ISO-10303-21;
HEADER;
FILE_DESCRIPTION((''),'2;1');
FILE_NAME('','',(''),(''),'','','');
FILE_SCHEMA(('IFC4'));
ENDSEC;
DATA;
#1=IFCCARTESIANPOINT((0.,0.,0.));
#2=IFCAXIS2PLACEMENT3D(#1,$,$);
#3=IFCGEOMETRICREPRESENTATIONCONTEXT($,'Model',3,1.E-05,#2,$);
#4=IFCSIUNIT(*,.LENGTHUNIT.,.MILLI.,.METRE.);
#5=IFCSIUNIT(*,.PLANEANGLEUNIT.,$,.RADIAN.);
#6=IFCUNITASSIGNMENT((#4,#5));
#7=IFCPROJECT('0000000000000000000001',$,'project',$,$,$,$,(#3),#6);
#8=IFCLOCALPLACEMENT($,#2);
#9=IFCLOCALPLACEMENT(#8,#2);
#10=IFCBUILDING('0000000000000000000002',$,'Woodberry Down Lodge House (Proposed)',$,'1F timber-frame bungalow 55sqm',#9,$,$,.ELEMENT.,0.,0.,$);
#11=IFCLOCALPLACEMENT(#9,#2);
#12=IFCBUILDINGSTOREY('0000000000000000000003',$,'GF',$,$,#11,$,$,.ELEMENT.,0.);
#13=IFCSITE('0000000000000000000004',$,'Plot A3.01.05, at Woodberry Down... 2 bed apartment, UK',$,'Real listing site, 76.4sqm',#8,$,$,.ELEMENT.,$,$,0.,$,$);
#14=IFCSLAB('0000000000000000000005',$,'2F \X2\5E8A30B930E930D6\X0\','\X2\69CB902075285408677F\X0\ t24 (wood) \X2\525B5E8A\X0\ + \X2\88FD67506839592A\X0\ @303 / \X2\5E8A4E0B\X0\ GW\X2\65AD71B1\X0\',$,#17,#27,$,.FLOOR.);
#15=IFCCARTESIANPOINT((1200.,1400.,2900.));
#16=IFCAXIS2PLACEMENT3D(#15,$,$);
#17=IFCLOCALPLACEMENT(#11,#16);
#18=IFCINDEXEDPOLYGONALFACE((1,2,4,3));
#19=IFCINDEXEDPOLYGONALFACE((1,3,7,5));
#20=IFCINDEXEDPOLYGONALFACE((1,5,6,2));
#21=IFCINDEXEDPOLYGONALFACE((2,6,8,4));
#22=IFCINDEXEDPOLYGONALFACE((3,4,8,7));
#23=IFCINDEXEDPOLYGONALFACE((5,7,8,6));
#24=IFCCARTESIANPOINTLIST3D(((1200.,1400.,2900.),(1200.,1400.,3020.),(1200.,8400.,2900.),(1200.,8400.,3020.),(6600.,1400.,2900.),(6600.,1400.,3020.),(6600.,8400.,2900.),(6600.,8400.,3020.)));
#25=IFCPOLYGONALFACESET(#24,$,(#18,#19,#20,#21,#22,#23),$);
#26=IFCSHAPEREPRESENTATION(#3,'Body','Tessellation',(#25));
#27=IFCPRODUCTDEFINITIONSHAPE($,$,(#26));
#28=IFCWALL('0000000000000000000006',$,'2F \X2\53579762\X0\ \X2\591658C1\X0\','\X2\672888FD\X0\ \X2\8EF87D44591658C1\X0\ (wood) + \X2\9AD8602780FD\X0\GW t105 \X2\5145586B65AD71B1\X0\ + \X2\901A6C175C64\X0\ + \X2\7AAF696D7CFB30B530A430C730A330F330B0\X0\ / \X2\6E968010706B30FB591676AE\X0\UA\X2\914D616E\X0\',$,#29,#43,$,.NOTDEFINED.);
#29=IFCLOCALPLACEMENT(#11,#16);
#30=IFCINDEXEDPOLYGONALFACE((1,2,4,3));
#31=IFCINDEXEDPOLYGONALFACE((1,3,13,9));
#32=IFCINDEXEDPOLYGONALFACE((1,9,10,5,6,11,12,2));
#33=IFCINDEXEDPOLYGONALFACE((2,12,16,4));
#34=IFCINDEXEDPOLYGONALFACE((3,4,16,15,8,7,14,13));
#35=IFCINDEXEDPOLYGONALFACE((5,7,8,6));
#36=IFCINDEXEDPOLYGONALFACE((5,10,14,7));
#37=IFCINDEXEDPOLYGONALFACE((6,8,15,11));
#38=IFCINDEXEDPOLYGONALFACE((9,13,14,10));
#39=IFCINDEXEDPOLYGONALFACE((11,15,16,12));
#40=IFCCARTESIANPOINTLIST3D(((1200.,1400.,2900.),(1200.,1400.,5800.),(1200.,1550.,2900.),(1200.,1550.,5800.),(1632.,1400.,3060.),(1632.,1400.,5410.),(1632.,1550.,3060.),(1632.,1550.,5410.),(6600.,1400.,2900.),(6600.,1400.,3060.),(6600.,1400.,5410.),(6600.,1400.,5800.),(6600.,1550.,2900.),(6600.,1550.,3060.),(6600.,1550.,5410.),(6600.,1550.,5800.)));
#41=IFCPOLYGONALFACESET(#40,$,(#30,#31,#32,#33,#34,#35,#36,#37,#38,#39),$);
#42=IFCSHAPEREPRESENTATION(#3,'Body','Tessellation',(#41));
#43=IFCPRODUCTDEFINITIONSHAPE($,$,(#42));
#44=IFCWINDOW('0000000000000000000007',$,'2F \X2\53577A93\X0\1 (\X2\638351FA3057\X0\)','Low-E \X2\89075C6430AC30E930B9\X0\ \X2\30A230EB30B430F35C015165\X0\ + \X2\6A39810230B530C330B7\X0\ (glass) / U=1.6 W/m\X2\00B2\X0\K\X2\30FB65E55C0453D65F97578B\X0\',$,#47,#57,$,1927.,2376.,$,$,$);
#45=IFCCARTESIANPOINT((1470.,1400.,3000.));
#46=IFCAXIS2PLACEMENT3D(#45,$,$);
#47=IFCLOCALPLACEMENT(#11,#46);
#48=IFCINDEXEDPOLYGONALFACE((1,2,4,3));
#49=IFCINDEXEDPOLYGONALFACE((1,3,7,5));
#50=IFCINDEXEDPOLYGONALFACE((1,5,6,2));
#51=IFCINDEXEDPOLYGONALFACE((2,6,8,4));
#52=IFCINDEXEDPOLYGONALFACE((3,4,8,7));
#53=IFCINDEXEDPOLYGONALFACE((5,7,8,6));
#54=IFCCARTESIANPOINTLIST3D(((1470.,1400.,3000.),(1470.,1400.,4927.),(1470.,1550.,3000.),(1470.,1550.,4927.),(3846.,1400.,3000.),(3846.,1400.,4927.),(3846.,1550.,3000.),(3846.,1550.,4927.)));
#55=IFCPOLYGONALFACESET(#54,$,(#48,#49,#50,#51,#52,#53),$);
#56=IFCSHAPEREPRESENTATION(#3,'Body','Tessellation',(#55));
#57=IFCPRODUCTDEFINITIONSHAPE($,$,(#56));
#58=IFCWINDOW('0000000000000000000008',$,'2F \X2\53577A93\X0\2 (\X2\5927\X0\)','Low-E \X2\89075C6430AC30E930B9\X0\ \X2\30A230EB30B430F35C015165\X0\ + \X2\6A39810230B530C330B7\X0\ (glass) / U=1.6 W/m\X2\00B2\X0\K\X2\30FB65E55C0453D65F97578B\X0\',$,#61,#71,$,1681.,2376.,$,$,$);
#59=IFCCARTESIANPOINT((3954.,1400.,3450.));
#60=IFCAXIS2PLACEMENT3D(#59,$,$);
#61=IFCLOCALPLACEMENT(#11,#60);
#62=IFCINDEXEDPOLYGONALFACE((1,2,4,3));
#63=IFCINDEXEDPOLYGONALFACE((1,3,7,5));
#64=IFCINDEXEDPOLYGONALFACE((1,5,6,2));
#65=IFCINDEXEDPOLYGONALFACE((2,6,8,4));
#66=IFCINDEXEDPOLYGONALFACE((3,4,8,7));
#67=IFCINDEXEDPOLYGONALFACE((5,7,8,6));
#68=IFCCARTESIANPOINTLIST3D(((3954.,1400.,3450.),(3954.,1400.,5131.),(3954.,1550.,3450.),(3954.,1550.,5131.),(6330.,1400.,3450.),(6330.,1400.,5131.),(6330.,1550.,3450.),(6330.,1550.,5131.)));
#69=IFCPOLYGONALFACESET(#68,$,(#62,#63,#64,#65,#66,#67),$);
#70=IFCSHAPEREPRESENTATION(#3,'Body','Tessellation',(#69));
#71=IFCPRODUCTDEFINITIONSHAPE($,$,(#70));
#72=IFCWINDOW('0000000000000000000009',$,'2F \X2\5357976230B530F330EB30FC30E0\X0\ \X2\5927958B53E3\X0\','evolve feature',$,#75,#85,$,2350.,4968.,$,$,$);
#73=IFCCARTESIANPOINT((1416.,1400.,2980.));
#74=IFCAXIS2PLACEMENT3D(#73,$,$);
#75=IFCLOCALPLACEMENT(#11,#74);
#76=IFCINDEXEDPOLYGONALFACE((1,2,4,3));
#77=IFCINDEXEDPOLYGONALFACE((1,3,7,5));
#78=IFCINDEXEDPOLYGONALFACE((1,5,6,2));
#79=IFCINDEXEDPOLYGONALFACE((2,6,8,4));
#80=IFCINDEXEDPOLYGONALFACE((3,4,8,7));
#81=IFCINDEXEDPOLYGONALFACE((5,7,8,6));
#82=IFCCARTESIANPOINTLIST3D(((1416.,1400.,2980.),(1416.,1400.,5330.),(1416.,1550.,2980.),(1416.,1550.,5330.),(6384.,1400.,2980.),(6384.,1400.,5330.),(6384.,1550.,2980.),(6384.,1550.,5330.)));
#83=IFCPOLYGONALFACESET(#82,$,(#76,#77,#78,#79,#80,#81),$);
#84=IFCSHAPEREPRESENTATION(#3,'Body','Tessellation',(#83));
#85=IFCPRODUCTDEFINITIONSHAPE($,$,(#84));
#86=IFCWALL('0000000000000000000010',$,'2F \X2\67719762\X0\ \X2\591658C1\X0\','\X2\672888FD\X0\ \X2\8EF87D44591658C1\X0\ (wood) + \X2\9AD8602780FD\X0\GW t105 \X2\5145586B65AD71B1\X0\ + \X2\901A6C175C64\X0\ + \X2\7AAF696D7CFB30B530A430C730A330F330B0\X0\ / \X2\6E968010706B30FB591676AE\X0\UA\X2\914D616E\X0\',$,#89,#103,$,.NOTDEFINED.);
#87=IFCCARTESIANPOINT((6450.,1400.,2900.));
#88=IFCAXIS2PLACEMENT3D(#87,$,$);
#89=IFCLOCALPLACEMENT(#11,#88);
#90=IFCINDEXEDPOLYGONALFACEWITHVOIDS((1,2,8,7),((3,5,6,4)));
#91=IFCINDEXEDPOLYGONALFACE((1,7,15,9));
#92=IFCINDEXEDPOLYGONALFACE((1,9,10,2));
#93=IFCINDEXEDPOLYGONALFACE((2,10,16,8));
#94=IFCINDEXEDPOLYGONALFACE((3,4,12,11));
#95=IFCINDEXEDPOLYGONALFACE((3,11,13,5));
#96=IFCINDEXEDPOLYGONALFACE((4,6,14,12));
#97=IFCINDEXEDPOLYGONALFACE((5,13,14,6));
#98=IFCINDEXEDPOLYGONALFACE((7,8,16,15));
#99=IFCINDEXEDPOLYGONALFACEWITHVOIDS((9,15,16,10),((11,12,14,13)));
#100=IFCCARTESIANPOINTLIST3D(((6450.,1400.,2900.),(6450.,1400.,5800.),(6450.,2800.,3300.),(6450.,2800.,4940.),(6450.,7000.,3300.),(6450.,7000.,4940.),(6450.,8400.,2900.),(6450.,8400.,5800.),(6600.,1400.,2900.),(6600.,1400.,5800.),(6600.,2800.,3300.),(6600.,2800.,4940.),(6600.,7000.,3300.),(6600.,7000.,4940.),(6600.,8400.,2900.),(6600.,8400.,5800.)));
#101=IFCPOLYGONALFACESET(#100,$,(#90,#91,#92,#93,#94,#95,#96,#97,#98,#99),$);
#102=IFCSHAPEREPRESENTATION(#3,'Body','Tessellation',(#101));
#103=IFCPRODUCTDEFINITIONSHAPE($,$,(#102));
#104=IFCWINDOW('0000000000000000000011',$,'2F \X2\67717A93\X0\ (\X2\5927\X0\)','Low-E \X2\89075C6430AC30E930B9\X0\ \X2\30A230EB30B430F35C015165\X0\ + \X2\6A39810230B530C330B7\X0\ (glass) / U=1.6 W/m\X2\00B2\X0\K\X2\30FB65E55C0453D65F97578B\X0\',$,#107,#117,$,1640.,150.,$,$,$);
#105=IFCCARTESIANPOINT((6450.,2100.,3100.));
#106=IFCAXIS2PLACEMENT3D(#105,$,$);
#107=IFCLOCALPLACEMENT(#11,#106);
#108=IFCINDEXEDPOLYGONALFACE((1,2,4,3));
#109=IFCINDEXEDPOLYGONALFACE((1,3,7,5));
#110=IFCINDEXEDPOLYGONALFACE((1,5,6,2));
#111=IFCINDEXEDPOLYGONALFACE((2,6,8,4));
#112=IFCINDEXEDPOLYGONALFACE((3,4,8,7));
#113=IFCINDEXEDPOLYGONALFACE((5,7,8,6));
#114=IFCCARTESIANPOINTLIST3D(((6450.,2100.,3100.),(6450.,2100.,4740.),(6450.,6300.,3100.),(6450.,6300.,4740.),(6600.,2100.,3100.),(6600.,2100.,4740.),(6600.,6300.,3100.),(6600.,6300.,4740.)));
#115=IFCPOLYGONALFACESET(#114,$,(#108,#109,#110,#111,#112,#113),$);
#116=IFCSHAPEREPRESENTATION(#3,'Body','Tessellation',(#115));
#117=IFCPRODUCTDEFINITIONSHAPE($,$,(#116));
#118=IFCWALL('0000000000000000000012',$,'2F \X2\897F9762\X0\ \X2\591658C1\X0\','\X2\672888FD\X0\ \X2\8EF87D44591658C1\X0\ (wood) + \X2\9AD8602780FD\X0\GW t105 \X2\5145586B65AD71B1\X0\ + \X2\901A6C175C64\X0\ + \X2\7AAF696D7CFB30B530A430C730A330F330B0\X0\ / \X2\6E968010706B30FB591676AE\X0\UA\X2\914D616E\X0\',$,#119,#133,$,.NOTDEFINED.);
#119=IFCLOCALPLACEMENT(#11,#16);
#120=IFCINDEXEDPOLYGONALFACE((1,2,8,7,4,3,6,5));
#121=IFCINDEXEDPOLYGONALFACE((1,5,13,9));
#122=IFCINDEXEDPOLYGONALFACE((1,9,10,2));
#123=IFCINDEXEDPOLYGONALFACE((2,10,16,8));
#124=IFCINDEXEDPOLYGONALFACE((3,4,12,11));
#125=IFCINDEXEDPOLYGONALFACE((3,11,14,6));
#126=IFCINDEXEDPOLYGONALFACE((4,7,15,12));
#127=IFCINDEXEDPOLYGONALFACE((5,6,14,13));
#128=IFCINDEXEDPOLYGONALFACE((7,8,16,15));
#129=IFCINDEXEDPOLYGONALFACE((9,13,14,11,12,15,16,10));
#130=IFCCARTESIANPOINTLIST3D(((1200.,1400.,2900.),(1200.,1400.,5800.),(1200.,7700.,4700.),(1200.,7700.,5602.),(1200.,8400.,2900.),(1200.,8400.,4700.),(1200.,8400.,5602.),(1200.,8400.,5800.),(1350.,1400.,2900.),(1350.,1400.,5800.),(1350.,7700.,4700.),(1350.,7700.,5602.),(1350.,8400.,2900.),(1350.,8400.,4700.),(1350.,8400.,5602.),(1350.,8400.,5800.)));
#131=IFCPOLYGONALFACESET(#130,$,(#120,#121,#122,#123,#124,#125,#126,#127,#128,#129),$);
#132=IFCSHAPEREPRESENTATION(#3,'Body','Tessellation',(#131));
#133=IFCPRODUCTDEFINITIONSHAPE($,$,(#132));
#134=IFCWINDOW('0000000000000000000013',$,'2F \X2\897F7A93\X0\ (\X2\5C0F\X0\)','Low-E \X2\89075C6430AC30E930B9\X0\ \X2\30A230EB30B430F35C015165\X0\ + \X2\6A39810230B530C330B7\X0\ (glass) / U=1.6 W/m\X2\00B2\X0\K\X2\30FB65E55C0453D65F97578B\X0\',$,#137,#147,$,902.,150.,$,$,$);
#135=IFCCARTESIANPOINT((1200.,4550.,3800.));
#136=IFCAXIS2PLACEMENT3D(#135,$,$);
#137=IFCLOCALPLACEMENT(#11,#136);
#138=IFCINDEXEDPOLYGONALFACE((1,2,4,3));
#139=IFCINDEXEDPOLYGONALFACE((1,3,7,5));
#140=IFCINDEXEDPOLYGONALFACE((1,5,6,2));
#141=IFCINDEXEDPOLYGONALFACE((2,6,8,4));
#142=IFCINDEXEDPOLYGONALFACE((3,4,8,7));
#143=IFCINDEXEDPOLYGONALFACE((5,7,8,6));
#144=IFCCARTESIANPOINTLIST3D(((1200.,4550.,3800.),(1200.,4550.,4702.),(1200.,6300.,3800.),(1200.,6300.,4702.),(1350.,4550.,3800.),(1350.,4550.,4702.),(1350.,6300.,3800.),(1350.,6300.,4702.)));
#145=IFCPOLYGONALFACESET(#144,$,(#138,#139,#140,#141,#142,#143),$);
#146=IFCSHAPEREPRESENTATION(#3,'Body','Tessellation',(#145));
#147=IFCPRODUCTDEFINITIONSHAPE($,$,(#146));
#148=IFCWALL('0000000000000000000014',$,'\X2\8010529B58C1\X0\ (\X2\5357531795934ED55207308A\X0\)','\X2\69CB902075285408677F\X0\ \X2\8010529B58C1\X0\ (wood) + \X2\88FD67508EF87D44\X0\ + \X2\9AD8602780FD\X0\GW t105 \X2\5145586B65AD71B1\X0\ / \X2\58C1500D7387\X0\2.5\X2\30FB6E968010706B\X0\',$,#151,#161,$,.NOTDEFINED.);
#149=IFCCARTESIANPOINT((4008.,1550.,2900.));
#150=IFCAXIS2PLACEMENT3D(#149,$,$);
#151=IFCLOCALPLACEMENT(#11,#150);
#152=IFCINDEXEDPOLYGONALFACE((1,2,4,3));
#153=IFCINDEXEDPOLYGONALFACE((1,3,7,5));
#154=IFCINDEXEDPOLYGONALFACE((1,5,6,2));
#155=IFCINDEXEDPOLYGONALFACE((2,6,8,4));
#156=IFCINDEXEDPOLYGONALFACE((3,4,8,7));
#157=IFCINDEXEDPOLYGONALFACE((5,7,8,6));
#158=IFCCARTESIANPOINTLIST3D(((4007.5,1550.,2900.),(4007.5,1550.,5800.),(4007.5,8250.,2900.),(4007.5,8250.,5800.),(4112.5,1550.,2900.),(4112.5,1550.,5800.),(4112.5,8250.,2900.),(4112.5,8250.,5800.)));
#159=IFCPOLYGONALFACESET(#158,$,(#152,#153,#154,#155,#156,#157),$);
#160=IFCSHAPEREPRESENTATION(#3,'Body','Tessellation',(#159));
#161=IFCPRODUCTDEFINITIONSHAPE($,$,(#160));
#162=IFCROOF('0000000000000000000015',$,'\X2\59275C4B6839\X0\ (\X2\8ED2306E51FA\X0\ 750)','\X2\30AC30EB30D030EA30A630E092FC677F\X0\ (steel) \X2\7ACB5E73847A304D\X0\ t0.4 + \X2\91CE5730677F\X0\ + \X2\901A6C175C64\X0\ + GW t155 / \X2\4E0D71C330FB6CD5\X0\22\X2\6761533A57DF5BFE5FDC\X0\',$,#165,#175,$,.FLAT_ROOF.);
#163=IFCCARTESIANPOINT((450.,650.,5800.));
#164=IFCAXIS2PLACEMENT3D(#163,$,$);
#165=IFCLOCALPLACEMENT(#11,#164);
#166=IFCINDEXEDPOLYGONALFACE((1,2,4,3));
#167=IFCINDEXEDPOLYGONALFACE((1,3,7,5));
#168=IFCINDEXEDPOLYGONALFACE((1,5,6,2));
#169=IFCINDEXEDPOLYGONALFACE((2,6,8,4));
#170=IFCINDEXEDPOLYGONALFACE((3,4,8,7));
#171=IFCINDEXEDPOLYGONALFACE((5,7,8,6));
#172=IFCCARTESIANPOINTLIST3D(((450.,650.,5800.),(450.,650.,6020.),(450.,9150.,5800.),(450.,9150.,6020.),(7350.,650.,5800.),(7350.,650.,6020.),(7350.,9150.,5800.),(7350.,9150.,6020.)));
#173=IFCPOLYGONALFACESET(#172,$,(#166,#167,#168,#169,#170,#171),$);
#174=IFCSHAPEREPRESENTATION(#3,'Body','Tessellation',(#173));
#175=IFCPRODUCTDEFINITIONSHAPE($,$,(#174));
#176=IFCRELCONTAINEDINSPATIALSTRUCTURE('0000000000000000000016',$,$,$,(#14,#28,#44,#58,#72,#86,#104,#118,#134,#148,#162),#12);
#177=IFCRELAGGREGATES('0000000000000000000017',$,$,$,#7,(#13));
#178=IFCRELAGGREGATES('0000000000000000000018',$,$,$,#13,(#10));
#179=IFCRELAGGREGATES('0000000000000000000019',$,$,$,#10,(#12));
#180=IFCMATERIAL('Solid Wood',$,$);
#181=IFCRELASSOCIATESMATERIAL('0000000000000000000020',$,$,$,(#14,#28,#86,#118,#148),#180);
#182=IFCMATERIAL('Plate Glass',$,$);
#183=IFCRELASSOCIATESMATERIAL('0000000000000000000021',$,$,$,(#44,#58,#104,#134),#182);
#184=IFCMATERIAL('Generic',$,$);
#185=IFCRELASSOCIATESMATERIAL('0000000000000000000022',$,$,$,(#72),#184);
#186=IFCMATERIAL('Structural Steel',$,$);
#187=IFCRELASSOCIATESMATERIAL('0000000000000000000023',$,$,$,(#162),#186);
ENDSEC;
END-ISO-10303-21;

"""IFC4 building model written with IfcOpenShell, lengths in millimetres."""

from ifc_helpers import new_model, si_unit, frame, frame_2d, origin, place, context, project, spatial, rectangle, extrude, material, element, fill, save


model = new_model("IFC4")

# Units and contexts
model_context = context("Model", 3, precision=1e-05, world=origin())
ifc_project = project(units=[si_unit("LENGTHUNIT", "METRE", prefix="MILLI"), si_unit("PLANEANGLEUNIT", "RADIAN")], contexts=[model_context])

# Site, building, storey
site_placement = place(None, origin())
site = spatial("IfcSite", under=ifc_project, at=site_placement, Name="Plot A3.01.05, at Woodberry Down... 2 bed apartment, UK", ObjectType="Real listing site, 76.4sqm", CompositionType="ELEMENT", RefElevation=0.0)
building_placement = place(site_placement, origin())
building = spatial("IfcBuilding", under=site, at=building_placement, Name="Woodberry Down Lodge House (Proposed)", ObjectType="1F timber-frame bungalow 55sqm", CompositionType="ELEMENT", ElevationOfRefHeight=0.0, ElevationOfTerrain=0.0)
storey_placement = place(building_placement, origin())
storey = spatial("IfcBuildingStorey", under=building, at=storey_placement, Name="GF", CompositionType="ELEMENT", Elevation=0.0)

# Slab
ifc_material_1 = material(Name="Solid Wood")
slab_placement = place(storey_placement, frame((1200.0, 1400.0, 2900.0)))
element("IfcSlab", 1, at=slab_placement, inside=storey, material=ifc_material_1, Name="2F 床スラブ", Description="構造用合板 t24 (wood) 剛床 + 製材根太 @303 / 床下 GW断熱", PredefinedType="FLOOR", context=model_context, shape_type="SweptSolid", body=[
    extrude(rectangle(XDim=5400.0, YDim=7000.0, at=frame_2d((2700.0, 3500.0))), frame((1200.0, 1400.0, 2900.0)), (0.0, 0.0, 1.0), 120.0),
])

# Wall, openings, windows
wall_1_placement = place(storey_placement, frame((1200.0, 1400.0, 2900.0)))
wall_1 = element("IfcWall", 2, at=wall_1_placement, inside=storey, material=ifc_material_1, Name="2F 南面 外壁", Description="木製 軸組外壁 (wood) + 高性能GW t105 充填断熱 + 通気層 + 窯業系サイディング / 準耐火・外皮UA配慮", PredefinedType="NOTDEFINED", context=model_context, shape_type="SweptSolid", body=[
    extrude(rectangle(XDim=5400.0, YDim=150.0, at=frame_2d((2700.0, 75.0))), frame((1200.0, 1400.0, 2900.0)), (0.0, 0.0, 1.0), 2900.0),
])
opening_1_placement = place(storey_placement, frame((1470.0, 1400.0, 3000.0)))
opening_1 = element("IfcOpeningElement", 3, at=opening_1_placement, cuts=wall_1, PredefinedType="NOTDEFINED", context=model_context, shape_type="SweptSolid", body=[
    extrude(rectangle(XDim=2376.0, YDim=150.0, at=frame_2d((1188.0, 75.0))), frame((1470.0, 1400.0, 3000.0)), (0.0, 0.0, 1.0), 1927.0),
])
opening_2_placement = place(storey_placement, frame((3954.0, 1400.0, 3450.0)))
opening_2 = element("IfcOpeningElement", 4, at=opening_2_placement, cuts=wall_1, PredefinedType="NOTDEFINED", context=model_context, shape_type="SweptSolid", body=[
    extrude(rectangle(XDim=2376.0, YDim=150.0, at=frame_2d((1188.0, 75.0))), frame((3954.0, 1400.0, 3450.0)), (0.0, 0.0, 1.0), 1681.0),
])
opening_3_placement = place(storey_placement, frame((1416.0, 1400.0, 2980.0)))
opening_3 = element("IfcOpeningElement", 5, at=opening_3_placement, cuts=wall_1, PredefinedType="NOTDEFINED", context=model_context, shape_type="SweptSolid", body=[
    extrude(rectangle(XDim=4968.0, YDim=150.0, at=frame_2d((2484.0, 75.0))), frame((1416.0, 1400.0, 2980.0)), (0.0, 0.0, 1.0), 2350.0),
])
ifc_material_2 = material(Name="Plate Glass")
window_1_placement = place(storey_placement, frame((1470.0, 1400.0, 3000.0)))
window_1 = element("IfcWindow", 6, at=window_1_placement, inside=storey, material=ifc_material_2, Name="2F 南窓1 (掃出し)", Description="Low-E 複層ガラス アルゴン封入 + 樹脂サッシ (glass) / U=1.6 W/m²K・日射取得型", OverallHeight=1927.0, OverallWidth=2376.0, context=model_context, shape_type="SweptSolid", body=[
    extrude(rectangle(XDim=2376.0, YDim=150.0, at=frame_2d((1188.0, 75.0))), frame((1470.0, 1400.0, 3000.0)), (0.0, 0.0, 1.0), 1927.0),
])
fill(opening_1, window_1)
window_2_placement = place(storey_placement, frame((3954.0, 1400.0, 3450.0)))
window_2 = element("IfcWindow", 7, at=window_2_placement, inside=storey, material=ifc_material_2, Name="2F 南窓2 (大)", Description="Low-E 複層ガラス アルゴン封入 + 樹脂サッシ (glass) / U=1.6 W/m²K・日射取得型", OverallHeight=1681.0, OverallWidth=2376.0, context=model_context, shape_type="SweptSolid", body=[
    extrude(rectangle(XDim=2376.0, YDim=150.0, at=frame_2d((1188.0, 75.0))), frame((3954.0, 1400.0, 3450.0)), (0.0, 0.0, 1.0), 1681.0),
])
fill(opening_2, window_2)
ifc_material_3 = material(Name="Generic")
window_3_placement = place(storey_placement, frame((1416.0, 1400.0, 2980.0)))
window_3 = element("IfcWindow", 8, at=window_3_placement, inside=storey, material=ifc_material_3, Name="2F 南面サンルーム 大開口", Description="evolve feature", OverallHeight=2350.0, OverallWidth=4968.0, context=model_context, shape_type="SweptSolid", body=[
    extrude(rectangle(XDim=4968.0, YDim=150.0, at=frame_2d((2484.0, 75.0))), frame((1416.0, 1400.0, 2980.0)), (0.0, 0.0, 1.0), 2350.0),
])
fill(opening_3, window_3)

# Walls, openings, windows
wall_2_placement = place(storey_placement, frame((6450.0, 1400.0, 2900.0)))
wall_2 = element("IfcWall", 9, at=wall_2_placement, inside=storey, material=ifc_material_1, Name="2F 東面 外壁", Description="木製 軸組外壁 (wood) + 高性能GW t105 充填断熱 + 通気層 + 窯業系サイディング / 準耐火・外皮UA配慮", PredefinedType="NOTDEFINED", context=model_context, shape_type="SweptSolid", body=[
    extrude(rectangle(XDim=150.0, YDim=7000.0, at=frame_2d((75.0, 3500.0))), frame((6450.0, 1400.0, 2900.0)), (0.0, 0.0, 1.0), 2900.0),
])
opening_4_placement = place(storey_placement, frame((6450.0, 2100.0, 3100.0)))
opening_4 = element("IfcOpeningElement", 10, at=opening_4_placement, cuts=wall_2, PredefinedType="NOTDEFINED", context=model_context, shape_type="SweptSolid", body=[
    extrude(rectangle(XDim=150.0, YDim=4200.0, at=frame_2d((75.0, 2100.0))), frame((6450.0, 2100.0, 3100.0)), (0.0, 0.0, 1.0), 1640.0),
])
window_4_placement = place(storey_placement, frame((6450.0, 2100.0, 3100.0)))
window_4 = element("IfcWindow", 11, at=window_4_placement, inside=storey, material=ifc_material_2, Name="2F 東窓 (大)", Description="Low-E 複層ガラス アルゴン封入 + 樹脂サッシ (glass) / U=1.6 W/m²K・日射取得型", OverallHeight=1640.0, OverallWidth=150.0, context=model_context, shape_type="SweptSolid", body=[
    extrude(rectangle(XDim=150.0, YDim=4200.0, at=frame_2d((75.0, 2100.0))), frame((6450.0, 2100.0, 3100.0)), (0.0, 0.0, 1.0), 1640.0),
])
fill(opening_4, window_4)
wall_3_placement = place(storey_placement, frame((1200.0, 1400.0, 2900.0)))
wall_3 = element("IfcWall", 12, at=wall_3_placement, inside=storey, material=ifc_material_1, Name="2F 西面 外壁", Description="木製 軸組外壁 (wood) + 高性能GW t105 充填断熱 + 通気層 + 窯業系サイディング / 準耐火・外皮UA配慮", PredefinedType="NOTDEFINED", context=model_context, shape_type="SweptSolid", body=[
    extrude(rectangle(XDim=150.0, YDim=7000.0, at=frame_2d((75.0, 3500.0))), frame((1200.0, 1400.0, 2900.0)), (0.0, 0.0, 1.0), 2900.0),
])
opening_5_placement = place(storey_placement, frame((1200.0, 4550.0, 3800.0)))
opening_5 = element("IfcOpeningElement", 13, at=opening_5_placement, cuts=wall_3, PredefinedType="NOTDEFINED", context=model_context, shape_type="SweptSolid", body=[
    extrude(rectangle(XDim=150.0, YDim=1750.0, at=frame_2d((75.0, 875.0))), frame((1200.0, 4550.0, 3800.0)), (0.0, 0.0, 1.0), 902.0),
])
window_5_placement = place(storey_placement, frame((1200.0, 4550.0, 3800.0)))
window_5 = element("IfcWindow", 14, at=window_5_placement, inside=storey, material=ifc_material_2, Name="2F 西窓 (小)", Description="Low-E 複層ガラス アルゴン封入 + 樹脂サッシ (glass) / U=1.6 W/m²K・日射取得型", OverallHeight=902.0, OverallWidth=150.0, context=model_context, shape_type="SweptSolid", body=[
    extrude(rectangle(XDim=150.0, YDim=1750.0, at=frame_2d((75.0, 875.0))), frame((1200.0, 4550.0, 3800.0)), (0.0, 0.0, 1.0), 902.0),
])
fill(opening_5, window_5)

# Wall
wall_4_placement = place(storey_placement, frame((4008.0, 1550.0, 2900.0)))
element("IfcWall", 15, at=wall_4_placement, inside=storey, material=ifc_material_1, Name="耐力壁 (南北間仕切り)", Description="構造用合板 耐力壁 (wood) + 製材軸組 + 高性能GW t105 充填断熱 / 壁倍率2.5・準耐火", PredefinedType="NOTDEFINED", context=model_context, shape_type="SweptSolid", body=[
    extrude(rectangle(XDim=105.0, YDim=6700.0, at=frame_2d((52.0, 3350.0))), frame((4008.0, 1550.0, 2900.0)), (0.0, 0.0, 1.0), 2900.0),
])

# Roof
ifc_material_4 = material(Name="Structural Steel")
roof_placement = place(storey_placement, frame((450.0, 650.0, 5800.0)))
element("IfcRoof", 16, at=roof_placement, inside=storey, material=ifc_material_4, Name="大屋根 (軒の出 750)", Description="ガルバリウム鋼板 (steel) 立平葺き t0.4 + 野地板 + 通気層 + GW t155 / 不燃・法22条区域対応", PredefinedType="FLAT_ROOF", context=model_context, shape_type="SweptSolid", body=[
    extrude(rectangle(XDim=6900.0, YDim=8500.0, at=frame_2d((3450.0, 4250.0))), frame((450.0, 650.0, 5800.0)), (0.0, 0.0, 1.0), 220.0),
])

save(model, "model.ifc")
